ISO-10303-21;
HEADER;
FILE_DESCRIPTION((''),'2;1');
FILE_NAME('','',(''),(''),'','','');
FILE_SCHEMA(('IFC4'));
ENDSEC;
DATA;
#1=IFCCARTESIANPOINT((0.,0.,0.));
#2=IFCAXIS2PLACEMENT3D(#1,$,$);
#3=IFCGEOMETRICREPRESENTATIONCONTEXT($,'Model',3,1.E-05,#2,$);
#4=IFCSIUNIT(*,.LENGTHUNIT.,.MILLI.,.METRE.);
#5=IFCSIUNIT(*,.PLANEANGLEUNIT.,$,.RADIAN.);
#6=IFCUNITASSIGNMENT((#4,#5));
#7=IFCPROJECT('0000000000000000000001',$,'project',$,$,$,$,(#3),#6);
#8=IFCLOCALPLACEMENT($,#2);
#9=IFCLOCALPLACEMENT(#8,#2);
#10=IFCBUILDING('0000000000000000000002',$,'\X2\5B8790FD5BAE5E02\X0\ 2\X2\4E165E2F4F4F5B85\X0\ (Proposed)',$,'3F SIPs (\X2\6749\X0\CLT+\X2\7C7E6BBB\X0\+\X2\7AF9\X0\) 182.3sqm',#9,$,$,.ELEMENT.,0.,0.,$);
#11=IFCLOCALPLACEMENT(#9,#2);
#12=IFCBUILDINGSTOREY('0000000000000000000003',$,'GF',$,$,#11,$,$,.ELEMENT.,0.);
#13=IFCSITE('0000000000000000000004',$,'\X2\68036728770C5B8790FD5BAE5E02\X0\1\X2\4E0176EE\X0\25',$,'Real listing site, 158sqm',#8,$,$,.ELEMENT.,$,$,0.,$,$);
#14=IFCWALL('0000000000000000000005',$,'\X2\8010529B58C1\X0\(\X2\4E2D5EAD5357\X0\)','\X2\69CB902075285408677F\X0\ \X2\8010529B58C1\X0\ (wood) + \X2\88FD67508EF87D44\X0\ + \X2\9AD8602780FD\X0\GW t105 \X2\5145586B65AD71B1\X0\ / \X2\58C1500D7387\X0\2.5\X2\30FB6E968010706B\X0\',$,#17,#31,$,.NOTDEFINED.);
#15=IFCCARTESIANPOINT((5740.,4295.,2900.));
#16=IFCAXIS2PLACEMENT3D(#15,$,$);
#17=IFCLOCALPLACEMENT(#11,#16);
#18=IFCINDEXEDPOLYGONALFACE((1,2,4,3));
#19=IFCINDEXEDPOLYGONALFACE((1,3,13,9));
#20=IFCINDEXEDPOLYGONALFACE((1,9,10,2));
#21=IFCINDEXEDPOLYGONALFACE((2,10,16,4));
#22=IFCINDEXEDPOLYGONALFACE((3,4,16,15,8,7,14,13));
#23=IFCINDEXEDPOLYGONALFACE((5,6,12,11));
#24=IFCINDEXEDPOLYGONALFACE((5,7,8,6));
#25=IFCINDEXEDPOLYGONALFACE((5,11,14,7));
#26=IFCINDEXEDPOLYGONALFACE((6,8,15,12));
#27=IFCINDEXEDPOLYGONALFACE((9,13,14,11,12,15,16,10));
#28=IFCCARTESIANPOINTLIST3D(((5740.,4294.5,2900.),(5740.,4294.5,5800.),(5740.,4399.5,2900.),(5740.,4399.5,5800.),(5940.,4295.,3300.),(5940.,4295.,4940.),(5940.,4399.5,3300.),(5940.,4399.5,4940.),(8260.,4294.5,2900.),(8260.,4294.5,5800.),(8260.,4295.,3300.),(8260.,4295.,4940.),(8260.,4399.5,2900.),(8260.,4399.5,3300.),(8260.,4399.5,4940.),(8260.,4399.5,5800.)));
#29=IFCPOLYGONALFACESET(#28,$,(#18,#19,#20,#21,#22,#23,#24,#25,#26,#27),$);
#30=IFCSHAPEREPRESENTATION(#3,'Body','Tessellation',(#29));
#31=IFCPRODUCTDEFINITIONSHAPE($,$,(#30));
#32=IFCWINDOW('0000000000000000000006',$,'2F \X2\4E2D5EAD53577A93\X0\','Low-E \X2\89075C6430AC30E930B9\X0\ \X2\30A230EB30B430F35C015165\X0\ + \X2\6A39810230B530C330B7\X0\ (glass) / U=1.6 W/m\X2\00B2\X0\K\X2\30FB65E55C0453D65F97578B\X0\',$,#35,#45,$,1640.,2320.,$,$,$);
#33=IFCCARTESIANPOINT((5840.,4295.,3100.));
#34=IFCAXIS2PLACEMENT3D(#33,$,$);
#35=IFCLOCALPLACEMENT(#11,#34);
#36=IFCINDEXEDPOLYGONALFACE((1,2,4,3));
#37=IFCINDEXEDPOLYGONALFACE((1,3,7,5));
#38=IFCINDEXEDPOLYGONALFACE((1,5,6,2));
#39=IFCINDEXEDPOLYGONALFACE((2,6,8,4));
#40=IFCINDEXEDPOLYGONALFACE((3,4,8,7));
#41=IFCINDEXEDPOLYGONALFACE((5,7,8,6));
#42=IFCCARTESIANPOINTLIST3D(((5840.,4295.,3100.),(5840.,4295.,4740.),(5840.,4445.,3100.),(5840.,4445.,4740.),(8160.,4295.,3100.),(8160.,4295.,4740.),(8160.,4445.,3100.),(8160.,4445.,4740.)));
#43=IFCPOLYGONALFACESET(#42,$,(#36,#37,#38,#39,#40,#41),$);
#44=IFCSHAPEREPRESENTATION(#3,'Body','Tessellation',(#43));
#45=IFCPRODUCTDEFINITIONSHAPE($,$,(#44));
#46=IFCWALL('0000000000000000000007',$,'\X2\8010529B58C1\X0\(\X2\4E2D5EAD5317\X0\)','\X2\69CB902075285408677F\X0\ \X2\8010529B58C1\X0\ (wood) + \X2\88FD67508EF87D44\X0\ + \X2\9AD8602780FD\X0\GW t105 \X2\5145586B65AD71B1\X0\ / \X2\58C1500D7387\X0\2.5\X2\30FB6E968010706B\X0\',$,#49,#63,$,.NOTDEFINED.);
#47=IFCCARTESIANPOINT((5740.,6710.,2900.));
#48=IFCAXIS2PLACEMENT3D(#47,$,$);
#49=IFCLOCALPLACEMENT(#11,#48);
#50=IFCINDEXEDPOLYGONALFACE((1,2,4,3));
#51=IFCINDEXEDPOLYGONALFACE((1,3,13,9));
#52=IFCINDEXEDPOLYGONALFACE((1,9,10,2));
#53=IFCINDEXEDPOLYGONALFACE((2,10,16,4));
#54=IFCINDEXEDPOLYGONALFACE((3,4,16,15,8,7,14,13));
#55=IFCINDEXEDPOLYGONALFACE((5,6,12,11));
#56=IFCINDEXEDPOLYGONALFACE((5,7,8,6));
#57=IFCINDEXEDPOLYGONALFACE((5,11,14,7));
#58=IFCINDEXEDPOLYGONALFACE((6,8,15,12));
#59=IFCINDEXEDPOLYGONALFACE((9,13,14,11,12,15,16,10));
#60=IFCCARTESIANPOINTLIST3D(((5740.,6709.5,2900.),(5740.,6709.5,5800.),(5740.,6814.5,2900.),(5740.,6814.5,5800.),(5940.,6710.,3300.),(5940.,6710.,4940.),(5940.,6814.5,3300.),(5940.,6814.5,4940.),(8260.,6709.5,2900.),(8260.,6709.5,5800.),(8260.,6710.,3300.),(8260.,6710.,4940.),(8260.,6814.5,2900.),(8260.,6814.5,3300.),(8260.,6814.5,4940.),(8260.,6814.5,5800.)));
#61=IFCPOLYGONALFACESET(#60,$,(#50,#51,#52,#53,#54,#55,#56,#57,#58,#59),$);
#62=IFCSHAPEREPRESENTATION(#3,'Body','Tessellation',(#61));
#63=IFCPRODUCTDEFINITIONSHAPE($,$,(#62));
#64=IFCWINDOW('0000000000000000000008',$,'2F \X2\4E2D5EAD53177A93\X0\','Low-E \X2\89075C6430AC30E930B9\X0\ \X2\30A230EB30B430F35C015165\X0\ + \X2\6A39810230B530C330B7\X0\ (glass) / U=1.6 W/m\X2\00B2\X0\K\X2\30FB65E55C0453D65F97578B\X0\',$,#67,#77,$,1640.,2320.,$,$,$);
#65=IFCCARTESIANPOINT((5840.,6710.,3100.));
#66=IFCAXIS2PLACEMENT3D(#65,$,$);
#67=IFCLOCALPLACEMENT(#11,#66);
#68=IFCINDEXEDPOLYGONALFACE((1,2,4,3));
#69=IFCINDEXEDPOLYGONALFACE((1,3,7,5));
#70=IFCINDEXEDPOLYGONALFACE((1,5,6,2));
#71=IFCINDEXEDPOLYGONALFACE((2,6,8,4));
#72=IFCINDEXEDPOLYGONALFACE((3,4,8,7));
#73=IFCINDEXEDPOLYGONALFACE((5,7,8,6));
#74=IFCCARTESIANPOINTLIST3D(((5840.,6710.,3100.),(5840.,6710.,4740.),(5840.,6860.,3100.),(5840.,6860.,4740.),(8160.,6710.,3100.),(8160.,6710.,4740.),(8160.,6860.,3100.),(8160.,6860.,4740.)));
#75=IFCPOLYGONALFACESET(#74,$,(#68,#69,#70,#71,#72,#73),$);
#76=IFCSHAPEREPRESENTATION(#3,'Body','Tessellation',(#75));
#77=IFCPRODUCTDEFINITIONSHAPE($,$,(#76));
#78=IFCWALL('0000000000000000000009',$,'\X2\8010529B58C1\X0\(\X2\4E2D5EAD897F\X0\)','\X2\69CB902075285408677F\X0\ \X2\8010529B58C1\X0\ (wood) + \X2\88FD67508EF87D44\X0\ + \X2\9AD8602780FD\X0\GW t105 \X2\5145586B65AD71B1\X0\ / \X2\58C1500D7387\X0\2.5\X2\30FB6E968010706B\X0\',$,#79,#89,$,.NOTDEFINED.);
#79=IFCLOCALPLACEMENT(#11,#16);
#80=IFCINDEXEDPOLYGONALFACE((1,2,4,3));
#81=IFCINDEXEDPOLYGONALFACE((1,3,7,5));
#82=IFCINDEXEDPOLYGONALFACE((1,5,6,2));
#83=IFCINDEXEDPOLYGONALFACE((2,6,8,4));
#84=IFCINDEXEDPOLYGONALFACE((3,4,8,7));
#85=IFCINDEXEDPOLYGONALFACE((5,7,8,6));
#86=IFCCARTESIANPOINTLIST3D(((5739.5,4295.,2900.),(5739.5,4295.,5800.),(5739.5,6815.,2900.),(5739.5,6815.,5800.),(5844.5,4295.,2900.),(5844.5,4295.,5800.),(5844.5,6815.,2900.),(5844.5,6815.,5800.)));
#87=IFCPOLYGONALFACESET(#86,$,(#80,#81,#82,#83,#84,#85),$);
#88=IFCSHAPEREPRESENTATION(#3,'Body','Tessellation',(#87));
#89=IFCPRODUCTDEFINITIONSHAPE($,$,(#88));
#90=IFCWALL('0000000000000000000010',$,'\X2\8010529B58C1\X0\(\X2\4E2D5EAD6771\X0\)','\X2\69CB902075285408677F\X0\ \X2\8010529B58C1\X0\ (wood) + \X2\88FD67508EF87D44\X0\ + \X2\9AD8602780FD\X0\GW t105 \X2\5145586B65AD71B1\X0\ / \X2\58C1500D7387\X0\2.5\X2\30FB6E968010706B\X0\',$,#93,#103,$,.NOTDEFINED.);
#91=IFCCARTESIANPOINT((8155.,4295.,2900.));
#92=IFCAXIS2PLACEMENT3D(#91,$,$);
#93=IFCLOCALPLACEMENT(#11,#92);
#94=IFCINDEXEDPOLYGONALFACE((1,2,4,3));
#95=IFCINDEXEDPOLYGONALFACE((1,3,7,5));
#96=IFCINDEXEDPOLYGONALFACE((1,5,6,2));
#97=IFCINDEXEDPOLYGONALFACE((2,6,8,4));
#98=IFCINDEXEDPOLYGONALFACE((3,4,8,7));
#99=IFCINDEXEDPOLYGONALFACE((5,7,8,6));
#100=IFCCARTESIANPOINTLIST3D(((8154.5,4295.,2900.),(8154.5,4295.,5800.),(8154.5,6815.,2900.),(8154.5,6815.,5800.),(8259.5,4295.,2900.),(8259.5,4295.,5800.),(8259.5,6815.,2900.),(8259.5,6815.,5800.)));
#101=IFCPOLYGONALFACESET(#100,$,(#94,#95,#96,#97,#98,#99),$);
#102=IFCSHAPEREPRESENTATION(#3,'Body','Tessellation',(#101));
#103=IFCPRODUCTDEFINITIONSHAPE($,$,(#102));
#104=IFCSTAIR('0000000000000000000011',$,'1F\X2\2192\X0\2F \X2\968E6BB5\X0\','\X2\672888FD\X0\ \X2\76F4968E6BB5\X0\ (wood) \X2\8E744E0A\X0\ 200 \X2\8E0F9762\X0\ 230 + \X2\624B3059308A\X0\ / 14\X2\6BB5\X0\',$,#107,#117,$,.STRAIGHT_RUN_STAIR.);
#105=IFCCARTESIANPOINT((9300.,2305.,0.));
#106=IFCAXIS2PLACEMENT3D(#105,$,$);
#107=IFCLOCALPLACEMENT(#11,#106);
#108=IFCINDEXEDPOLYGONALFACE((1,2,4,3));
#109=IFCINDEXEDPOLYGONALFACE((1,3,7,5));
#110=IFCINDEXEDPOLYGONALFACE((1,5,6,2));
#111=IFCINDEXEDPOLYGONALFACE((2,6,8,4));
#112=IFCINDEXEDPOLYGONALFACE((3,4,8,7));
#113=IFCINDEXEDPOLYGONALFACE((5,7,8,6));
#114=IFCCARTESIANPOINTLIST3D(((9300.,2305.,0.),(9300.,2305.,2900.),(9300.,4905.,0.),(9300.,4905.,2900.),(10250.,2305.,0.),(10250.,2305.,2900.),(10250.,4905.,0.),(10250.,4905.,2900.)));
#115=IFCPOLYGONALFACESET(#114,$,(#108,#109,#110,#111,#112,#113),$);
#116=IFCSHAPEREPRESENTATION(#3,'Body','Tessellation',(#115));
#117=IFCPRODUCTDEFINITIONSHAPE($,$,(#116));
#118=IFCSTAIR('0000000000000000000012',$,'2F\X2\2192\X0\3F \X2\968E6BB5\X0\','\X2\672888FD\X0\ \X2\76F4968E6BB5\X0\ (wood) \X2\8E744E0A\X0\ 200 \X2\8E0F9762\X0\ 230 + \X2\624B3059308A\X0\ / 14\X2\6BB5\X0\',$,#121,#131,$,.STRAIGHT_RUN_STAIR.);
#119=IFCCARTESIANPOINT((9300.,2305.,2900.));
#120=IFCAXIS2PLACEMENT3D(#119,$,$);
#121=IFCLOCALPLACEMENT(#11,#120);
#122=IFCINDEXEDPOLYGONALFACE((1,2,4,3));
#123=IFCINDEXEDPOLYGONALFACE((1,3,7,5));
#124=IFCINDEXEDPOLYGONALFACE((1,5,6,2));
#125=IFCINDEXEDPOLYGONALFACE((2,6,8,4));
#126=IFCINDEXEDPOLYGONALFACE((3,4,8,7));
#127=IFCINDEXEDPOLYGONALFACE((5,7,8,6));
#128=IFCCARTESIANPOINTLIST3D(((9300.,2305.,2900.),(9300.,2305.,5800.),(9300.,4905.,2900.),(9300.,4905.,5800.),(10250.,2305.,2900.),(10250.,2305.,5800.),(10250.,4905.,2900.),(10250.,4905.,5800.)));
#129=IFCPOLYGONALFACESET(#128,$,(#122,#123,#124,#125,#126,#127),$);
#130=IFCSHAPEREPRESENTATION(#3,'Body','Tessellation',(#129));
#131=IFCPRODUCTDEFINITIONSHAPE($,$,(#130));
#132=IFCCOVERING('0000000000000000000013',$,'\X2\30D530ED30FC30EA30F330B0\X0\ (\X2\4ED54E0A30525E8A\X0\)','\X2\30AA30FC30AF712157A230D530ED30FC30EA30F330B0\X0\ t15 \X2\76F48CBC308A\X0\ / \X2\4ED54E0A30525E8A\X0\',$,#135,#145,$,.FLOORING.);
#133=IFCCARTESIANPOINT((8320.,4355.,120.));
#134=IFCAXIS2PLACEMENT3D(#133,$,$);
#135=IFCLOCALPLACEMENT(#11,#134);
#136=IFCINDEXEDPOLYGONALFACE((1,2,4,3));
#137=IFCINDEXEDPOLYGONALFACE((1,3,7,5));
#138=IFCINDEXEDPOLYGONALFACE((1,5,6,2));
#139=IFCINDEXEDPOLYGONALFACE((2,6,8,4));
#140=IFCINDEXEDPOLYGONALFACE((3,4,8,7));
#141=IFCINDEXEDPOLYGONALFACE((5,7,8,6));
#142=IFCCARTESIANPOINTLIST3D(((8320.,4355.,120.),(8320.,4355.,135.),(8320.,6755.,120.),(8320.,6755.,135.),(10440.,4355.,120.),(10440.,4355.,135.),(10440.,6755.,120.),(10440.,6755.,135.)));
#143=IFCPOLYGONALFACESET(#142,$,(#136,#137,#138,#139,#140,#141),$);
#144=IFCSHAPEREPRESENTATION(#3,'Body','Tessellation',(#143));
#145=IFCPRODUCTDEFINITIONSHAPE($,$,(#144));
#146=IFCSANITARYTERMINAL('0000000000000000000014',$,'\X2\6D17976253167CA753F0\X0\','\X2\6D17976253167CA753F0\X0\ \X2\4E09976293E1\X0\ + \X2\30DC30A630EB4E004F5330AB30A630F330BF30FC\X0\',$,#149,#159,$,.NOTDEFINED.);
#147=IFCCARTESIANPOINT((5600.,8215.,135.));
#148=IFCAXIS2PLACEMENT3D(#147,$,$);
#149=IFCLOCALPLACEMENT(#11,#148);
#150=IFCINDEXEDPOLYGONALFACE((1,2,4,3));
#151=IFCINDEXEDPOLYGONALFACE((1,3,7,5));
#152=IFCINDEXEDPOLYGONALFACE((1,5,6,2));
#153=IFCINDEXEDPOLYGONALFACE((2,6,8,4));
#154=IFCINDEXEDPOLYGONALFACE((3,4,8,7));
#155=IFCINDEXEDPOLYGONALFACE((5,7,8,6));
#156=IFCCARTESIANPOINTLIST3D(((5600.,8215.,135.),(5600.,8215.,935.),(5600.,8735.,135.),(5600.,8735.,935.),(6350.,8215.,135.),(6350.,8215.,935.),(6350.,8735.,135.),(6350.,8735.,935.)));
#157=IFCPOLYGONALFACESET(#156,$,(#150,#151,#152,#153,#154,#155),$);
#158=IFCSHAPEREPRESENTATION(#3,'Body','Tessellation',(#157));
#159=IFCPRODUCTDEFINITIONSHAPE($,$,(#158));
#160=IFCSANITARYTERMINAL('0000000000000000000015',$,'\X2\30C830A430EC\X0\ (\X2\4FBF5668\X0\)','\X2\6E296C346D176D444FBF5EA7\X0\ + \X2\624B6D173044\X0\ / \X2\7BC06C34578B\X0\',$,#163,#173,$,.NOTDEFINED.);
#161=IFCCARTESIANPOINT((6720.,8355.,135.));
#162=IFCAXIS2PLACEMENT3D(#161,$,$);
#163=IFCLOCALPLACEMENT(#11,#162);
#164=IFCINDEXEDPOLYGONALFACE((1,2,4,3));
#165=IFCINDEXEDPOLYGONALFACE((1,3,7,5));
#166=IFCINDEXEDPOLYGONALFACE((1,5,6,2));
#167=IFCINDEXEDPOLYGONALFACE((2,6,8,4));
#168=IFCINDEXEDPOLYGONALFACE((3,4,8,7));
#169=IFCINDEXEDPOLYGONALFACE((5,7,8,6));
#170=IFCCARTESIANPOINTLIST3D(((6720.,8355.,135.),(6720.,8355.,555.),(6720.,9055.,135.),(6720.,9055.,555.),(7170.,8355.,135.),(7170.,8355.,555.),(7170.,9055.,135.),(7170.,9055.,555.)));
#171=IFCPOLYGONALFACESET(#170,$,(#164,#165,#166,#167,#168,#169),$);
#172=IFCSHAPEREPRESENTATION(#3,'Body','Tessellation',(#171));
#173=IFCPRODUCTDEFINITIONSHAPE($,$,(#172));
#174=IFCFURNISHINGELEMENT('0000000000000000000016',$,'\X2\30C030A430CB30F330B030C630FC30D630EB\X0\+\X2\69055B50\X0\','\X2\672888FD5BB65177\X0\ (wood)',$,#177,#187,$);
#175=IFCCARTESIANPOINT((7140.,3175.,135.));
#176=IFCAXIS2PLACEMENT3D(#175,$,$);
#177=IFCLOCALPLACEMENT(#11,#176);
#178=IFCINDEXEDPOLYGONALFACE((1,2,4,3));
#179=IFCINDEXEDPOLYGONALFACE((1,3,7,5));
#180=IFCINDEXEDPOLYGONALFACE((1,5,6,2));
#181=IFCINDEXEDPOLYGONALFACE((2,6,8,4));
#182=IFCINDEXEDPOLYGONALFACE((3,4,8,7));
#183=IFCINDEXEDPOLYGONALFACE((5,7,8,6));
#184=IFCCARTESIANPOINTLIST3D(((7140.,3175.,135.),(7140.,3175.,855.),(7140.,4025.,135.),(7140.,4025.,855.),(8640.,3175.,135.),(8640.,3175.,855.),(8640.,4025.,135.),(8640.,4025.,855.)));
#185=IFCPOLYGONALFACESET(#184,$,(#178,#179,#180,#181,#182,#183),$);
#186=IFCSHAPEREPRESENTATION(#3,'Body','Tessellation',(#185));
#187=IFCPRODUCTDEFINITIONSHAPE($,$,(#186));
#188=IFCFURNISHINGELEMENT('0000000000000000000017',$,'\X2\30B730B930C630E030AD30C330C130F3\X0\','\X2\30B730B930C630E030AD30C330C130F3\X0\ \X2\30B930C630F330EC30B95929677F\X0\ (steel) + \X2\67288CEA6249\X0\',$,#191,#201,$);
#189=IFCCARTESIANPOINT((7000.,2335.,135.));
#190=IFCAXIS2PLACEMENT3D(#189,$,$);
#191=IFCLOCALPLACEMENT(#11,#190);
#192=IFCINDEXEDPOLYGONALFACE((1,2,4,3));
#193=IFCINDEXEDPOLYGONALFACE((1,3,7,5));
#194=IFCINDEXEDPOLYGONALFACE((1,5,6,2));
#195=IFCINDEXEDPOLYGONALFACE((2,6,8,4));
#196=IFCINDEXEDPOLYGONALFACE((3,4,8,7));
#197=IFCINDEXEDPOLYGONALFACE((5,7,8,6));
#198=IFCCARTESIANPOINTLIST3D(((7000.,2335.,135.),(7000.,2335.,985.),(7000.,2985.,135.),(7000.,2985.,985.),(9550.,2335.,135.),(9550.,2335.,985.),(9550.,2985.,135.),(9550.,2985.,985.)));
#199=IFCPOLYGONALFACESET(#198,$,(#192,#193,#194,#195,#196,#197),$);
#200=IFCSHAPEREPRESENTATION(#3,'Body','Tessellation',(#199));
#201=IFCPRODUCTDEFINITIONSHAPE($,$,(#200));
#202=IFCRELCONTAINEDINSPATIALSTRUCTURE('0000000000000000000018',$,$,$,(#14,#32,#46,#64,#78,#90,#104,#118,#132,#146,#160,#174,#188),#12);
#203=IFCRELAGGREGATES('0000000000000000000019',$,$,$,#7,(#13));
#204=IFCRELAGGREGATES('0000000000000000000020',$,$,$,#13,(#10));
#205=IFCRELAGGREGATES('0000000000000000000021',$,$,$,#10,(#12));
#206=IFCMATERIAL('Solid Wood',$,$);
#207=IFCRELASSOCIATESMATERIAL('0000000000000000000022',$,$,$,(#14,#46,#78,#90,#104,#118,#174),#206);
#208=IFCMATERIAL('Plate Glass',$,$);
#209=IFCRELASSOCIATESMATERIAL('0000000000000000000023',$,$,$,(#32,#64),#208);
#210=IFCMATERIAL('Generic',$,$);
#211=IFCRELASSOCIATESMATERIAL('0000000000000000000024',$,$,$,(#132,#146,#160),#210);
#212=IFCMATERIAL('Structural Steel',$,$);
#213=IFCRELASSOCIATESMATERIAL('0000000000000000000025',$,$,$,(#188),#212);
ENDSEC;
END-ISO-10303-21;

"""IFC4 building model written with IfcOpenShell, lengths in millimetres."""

from ifc_helpers import new_model, si_unit, frame, frame_2d, origin, place, context, project, spatial, rectangle, extrude, material, element, fill, save


model = new_model("IFC4")

# Units and contexts
model_context = context("Model", 3, precision=1e-05, world=origin())
ifc_project = project(units=[si_unit("LENGTHUNIT", "METRE", prefix="MILLI"), si_unit("PLANEANGLEUNIT", "RADIAN")], contexts=[model_context])

# Site, building, storey
site_placement = place(None, origin())
site = spatial("IfcSite", under=ifc_project, at=site_placement, Name="栃木県宇都宮市1丁目25", ObjectType="Real listing site, 158sqm", CompositionType="ELEMENT", RefElevation=0.0)
building_placement = place(site_placement, origin())
building = spatial("IfcBuilding", under=site, at=building_placement, Name="宇都宮市 2世帯住宅 (Proposed)", ObjectType="3F SIPs (杉CLT+籾殻+竹) 182.3sqm", CompositionType="ELEMENT", ElevationOfRefHeight=0.0, ElevationOfTerrain=0.0)
storey_placement = place(building_placement, origin())
storey = spatial("IfcBuildingStorey", under=building, at=storey_placement, Name="GF", CompositionType="ELEMENT", Elevation=0.0)

# Shared definitions
ifc_material_1 = material(Name="Solid Wood")

# Shared definitions
ifc_material_2 = material(Name="Plate Glass")

# Walls, openings, windows
wall_1_placement = place(storey_placement, frame((5740.0, 4295.0, 2900.0)))
wall_1 = element("IfcWall", 1, at=wall_1_placement, inside=storey, material=ifc_material_1, Name="耐力壁(中庭南)", Description="構造用合板 耐力壁 (wood) + 製材軸組 + 高性能GW t105 充填断熱 / 壁倍率2.5・準耐火", PredefinedType="NOTDEFINED", context=model_context, shape_type="SweptSolid", body=[
    extrude(rectangle(XDim=2520.0, YDim=105.0, at=frame_2d((1260.0, 52.0))), frame((5740.0, 4295.0, 2900.0)), (0.0, 0.0, 1.0), 2900.0),
])
opening_1_placement = place(storey_placement, frame((5840.0, 4295.0, 3100.0)))
opening_1 = element("IfcOpeningElement", 2, at=opening_1_placement, cuts=wall_1, PredefinedType="NOTDEFINED", context=model_context, shape_type="SweptSolid", body=[
    extrude(rectangle(XDim=2320.0, YDim=150.0, at=frame_2d((1160.0, 75.0))), frame((5840.0, 4295.0, 3100.0)), (0.0, 0.0, 1.0), 1640.0),
])
window_1_placement = place(storey_placement, frame((5840.0, 4295.0, 3100.0)))
window_1 = element("IfcWindow", 3, at=window_1_placement, inside=storey, material=ifc_material_2, Name="2F 中庭南窓", Description="Low-E 複層ガラス アルゴン封入 + 樹脂サッシ (glass) / U=1.6 W/m²K・日射取得型", OverallHeight=1640.0, OverallWidth=2320.0, context=model_context, shape_type="SweptSolid", body=[
    extrude(rectangle(XDim=2320.0, YDim=150.0, at=frame_2d((1160.0, 75.0))), frame((5840.0, 4295.0, 3100.0)), (0.0, 0.0, 1.0), 1640.0),
])
fill(opening_1, window_1)
wall_2_placement = place(storey_placement, frame((5740.0, 6710.0, 2900.0)))
wall_2 = element("IfcWall", 4, at=wall_2_placement, inside=storey, material=ifc_material_1, Name="耐力壁(中庭北)", Description="構造用合板 耐力壁 (wood) + 製材軸組 + 高性能GW t105 充填断熱 / 壁倍率2.5・準耐火", PredefinedType="NOTDEFINED", context=model_context, shape_type="SweptSolid", body=[
    extrude(rectangle(XDim=2520.0, YDim=105.0, at=frame_2d((1260.0, 52.0))), frame((5740.0, 6710.0, 2900.0)), (0.0, 0.0, 1.0), 2900.0),
])
opening_2_placement = place(storey_placement, frame((5840.0, 6710.0, 3100.0)))
opening_2 = element("IfcOpeningElement", 5, at=opening_2_placement, cuts=wall_2, PredefinedType="NOTDEFINED", context=model_context, shape_type="SweptSolid", body=[
    extrude(rectangle(XDim=2320.0, YDim=150.0, at=frame_2d((1160.0, 75.0))), frame((5840.0, 6710.0, 3100.0)), (0.0, 0.0, 1.0), 1640.0),
])
window_2_placement = place(storey_placement, frame((5840.0, 6710.0, 3100.0)))
window_2 = element("IfcWindow", 6, at=window_2_placement, inside=storey, material=ifc_material_2, Name="2F 中庭北窓", Description="Low-E 複層ガラス アルゴン封入 + 樹脂サッシ (glass) / U=1.6 W/m²K・日射取得型", OverallHeight=1640.0, OverallWidth=2320.0, context=model_context, shape_type="SweptSolid", body=[
    extrude(rectangle(XDim=2320.0, YDim=150.0, at=frame_2d((1160.0, 75.0))), frame((5840.0, 6710.0, 3100.0)), (0.0, 0.0, 1.0), 1640.0),
])
fill(opening_2, window_2)

# Walls
wall_3_placement = place(storey_placement, frame((5740.0, 4295.0, 2900.0)))
element("IfcWall", 7, at=wall_3_placement, inside=storey, material=ifc_material_1, Name="耐力壁(中庭西)", Description="構造用合板 耐力壁 (wood) + 製材軸組 + 高性能GW t105 充填断熱 / 壁倍率2.5・準耐火", PredefinedType="NOTDEFINED", context=model_context, shape_type="SweptSolid", body=[
    extrude(rectangle(XDim=105.0, YDim=2520.0, at=frame_2d((52.0, 1260.0))), frame((5740.0, 4295.0, 2900.0)), (0.0, 0.0, 1.0), 2900.0),
])
wall_4_placement = place(storey_placement, frame((8155.0, 4295.0, 2900.0)))
element("IfcWall", 8, at=wall_4_placement, inside=storey, material=ifc_material_1, Name="耐力壁(中庭東)", Description="構造用合板 耐力壁 (wood) + 製材軸組 + 高性能GW t105 充填断熱 / 壁倍率2.5・準耐火", PredefinedType="NOTDEFINED", context=model_context, shape_type="SweptSolid", body=[
    extrude(rectangle(XDim=105.0, YDim=2520.0, at=frame_2d((52.0, 1260.0))), frame((8155.0, 4295.0, 2900.0)), (0.0, 0.0, 1.0), 2900.0),
])

# Stairs
stair_1_placement = place(storey_placement, frame((9300.0, 2305.0, 0.0)))
element("IfcStair", 9, at=stair_1_placement, inside=storey, material=ifc_material_1, Name="1F→2F 階段", Description="木製 直階段 (wood) 蹴上 200 踏面 230 + 手すり / 14段", PredefinedType="STRAIGHT_RUN_STAIR", context=model_context, shape_type="SweptSolid", body=[
    extrude(rectangle(XDim=950.0, YDim=2600.0, at=frame_2d((475.0, 1300.0))), frame((9300.0, 2305.0, 0.0)), (0.0, 0.0, 1.0), 2900.0),
])
stair_2_placement = place(storey_placement, frame((9300.0, 2305.0, 2900.0)))
element("IfcStair", 10, at=stair_2_placement, inside=storey, material=ifc_material_1, Name="2F→3F 階段", Description="木製 直階段 (wood) 蹴上 200 踏面 230 + 手すり / 14段", PredefinedType="STRAIGHT_RUN_STAIR", context=model_context, shape_type="SweptSolid", body=[
    extrude(rectangle(XDim=950.0, YDim=2600.0, at=frame_2d((475.0, 1300.0))), frame((9300.0, 2305.0, 2900.0)), (0.0, 0.0, 1.0), 2900.0),
])

# Covering
ifc_material_3 = material(Name="Generic")
covering_placement = place(storey_placement, frame((8320.0, 4355.0, 120.0)))
element("IfcCovering", 11, at=covering_placement, inside=storey, material=ifc_material_3, Name="フローリング (仕上げ床)", Description="オーク無垢フローリング t15 直貼り / 仕上げ床", PredefinedType="FLOORING", context=model_context, shape_type="SweptSolid", body=[
    extrude(rectangle(XDim=2120.0, YDim=2400.0, at=frame_2d((1060.0, 1200.0))), frame((8320.0, 4355.0, 120.0)), (0.0, 0.0, 1.0), 15.0),
])

# Sanitary terminals
sanitary_terminal_1_placement = place(storey_placement, frame((5600.0, 8215.0, 135.0)))
element("IfcSanitaryTerminal", 12, at=sanitary_terminal_1_placement, inside=storey, material=ifc_material_3, Name="洗面化粧台", Description="洗面化粧台 三面鏡 + ボウル一体カウンター", PredefinedType="NOTDEFINED", context=model_context, shape_type="SweptSolid", body=[
    extrude(rectangle(XDim=750.0, YDim=520.0, at=frame_2d((375.0, 260.0))), frame((5600.0, 8215.0, 135.0)), (0.0, 0.0, 1.0), 800.0),
])
sanitary_terminal_2_placement = place(storey_placement, frame((6720.0, 8355.0, 135.0)))
element("IfcSanitaryTerminal", 13, at=sanitary_terminal_2_placement, inside=storey, material=ifc_material_3, Name="トイレ (便器)", Description="温水洗浄便座 + 手洗い / 節水型", PredefinedType="NOTDEFINED", context=model_context, shape_type="SweptSolid", body=[
    extrude(rectangle(XDim=450.0, YDim=700.0, at=frame_2d((225.0, 350.0))), frame((6720.0, 8355.0, 135.0)), (0.0, 0.0, 1.0), 420.0),
])

# Furnishing elements
furnishing_1_placement = place(storey_placement, frame((7140.0, 3175.0, 135.0)))
element("IfcFurnishingElement", 14, at=furnishing_1_placement, inside=storey, material=ifc_material_1, Name="ダイニングテーブル+椅子", Description="木製家具 (wood)", context=model_context, shape_type="SweptSolid", body=[
    extrude(rectangle(XDim=1500.0, YDim=850.0, at=frame_2d((750.0, 425.0))), frame((7140.0, 3175.0, 135.0)), (0.0, 0.0, 1.0), 720.0),
])
ifc_material_4 = material(Name="Structural Steel")
furnishing_2_placement = place(storey_placement, frame((7000.0, 2335.0, 135.0)))
element("IfcFurnishingElement", 15, at=furnishing_2_placement, inside=storey, material=ifc_material_4, Name="システムキッチン", Description="システムキッチン ステンレス天板 (steel) + 木質扉", context=model_context, shape_type="SweptSolid", body=[
    extrude(rectangle(XDim=2550.0, YDim=650.0, at=frame_2d((1275.0, 325.0))), frame((7000.0, 2335.0, 135.0)), (0.0, 0.0, 1.0), 850.0),
])

save(model, "model.ifc")
